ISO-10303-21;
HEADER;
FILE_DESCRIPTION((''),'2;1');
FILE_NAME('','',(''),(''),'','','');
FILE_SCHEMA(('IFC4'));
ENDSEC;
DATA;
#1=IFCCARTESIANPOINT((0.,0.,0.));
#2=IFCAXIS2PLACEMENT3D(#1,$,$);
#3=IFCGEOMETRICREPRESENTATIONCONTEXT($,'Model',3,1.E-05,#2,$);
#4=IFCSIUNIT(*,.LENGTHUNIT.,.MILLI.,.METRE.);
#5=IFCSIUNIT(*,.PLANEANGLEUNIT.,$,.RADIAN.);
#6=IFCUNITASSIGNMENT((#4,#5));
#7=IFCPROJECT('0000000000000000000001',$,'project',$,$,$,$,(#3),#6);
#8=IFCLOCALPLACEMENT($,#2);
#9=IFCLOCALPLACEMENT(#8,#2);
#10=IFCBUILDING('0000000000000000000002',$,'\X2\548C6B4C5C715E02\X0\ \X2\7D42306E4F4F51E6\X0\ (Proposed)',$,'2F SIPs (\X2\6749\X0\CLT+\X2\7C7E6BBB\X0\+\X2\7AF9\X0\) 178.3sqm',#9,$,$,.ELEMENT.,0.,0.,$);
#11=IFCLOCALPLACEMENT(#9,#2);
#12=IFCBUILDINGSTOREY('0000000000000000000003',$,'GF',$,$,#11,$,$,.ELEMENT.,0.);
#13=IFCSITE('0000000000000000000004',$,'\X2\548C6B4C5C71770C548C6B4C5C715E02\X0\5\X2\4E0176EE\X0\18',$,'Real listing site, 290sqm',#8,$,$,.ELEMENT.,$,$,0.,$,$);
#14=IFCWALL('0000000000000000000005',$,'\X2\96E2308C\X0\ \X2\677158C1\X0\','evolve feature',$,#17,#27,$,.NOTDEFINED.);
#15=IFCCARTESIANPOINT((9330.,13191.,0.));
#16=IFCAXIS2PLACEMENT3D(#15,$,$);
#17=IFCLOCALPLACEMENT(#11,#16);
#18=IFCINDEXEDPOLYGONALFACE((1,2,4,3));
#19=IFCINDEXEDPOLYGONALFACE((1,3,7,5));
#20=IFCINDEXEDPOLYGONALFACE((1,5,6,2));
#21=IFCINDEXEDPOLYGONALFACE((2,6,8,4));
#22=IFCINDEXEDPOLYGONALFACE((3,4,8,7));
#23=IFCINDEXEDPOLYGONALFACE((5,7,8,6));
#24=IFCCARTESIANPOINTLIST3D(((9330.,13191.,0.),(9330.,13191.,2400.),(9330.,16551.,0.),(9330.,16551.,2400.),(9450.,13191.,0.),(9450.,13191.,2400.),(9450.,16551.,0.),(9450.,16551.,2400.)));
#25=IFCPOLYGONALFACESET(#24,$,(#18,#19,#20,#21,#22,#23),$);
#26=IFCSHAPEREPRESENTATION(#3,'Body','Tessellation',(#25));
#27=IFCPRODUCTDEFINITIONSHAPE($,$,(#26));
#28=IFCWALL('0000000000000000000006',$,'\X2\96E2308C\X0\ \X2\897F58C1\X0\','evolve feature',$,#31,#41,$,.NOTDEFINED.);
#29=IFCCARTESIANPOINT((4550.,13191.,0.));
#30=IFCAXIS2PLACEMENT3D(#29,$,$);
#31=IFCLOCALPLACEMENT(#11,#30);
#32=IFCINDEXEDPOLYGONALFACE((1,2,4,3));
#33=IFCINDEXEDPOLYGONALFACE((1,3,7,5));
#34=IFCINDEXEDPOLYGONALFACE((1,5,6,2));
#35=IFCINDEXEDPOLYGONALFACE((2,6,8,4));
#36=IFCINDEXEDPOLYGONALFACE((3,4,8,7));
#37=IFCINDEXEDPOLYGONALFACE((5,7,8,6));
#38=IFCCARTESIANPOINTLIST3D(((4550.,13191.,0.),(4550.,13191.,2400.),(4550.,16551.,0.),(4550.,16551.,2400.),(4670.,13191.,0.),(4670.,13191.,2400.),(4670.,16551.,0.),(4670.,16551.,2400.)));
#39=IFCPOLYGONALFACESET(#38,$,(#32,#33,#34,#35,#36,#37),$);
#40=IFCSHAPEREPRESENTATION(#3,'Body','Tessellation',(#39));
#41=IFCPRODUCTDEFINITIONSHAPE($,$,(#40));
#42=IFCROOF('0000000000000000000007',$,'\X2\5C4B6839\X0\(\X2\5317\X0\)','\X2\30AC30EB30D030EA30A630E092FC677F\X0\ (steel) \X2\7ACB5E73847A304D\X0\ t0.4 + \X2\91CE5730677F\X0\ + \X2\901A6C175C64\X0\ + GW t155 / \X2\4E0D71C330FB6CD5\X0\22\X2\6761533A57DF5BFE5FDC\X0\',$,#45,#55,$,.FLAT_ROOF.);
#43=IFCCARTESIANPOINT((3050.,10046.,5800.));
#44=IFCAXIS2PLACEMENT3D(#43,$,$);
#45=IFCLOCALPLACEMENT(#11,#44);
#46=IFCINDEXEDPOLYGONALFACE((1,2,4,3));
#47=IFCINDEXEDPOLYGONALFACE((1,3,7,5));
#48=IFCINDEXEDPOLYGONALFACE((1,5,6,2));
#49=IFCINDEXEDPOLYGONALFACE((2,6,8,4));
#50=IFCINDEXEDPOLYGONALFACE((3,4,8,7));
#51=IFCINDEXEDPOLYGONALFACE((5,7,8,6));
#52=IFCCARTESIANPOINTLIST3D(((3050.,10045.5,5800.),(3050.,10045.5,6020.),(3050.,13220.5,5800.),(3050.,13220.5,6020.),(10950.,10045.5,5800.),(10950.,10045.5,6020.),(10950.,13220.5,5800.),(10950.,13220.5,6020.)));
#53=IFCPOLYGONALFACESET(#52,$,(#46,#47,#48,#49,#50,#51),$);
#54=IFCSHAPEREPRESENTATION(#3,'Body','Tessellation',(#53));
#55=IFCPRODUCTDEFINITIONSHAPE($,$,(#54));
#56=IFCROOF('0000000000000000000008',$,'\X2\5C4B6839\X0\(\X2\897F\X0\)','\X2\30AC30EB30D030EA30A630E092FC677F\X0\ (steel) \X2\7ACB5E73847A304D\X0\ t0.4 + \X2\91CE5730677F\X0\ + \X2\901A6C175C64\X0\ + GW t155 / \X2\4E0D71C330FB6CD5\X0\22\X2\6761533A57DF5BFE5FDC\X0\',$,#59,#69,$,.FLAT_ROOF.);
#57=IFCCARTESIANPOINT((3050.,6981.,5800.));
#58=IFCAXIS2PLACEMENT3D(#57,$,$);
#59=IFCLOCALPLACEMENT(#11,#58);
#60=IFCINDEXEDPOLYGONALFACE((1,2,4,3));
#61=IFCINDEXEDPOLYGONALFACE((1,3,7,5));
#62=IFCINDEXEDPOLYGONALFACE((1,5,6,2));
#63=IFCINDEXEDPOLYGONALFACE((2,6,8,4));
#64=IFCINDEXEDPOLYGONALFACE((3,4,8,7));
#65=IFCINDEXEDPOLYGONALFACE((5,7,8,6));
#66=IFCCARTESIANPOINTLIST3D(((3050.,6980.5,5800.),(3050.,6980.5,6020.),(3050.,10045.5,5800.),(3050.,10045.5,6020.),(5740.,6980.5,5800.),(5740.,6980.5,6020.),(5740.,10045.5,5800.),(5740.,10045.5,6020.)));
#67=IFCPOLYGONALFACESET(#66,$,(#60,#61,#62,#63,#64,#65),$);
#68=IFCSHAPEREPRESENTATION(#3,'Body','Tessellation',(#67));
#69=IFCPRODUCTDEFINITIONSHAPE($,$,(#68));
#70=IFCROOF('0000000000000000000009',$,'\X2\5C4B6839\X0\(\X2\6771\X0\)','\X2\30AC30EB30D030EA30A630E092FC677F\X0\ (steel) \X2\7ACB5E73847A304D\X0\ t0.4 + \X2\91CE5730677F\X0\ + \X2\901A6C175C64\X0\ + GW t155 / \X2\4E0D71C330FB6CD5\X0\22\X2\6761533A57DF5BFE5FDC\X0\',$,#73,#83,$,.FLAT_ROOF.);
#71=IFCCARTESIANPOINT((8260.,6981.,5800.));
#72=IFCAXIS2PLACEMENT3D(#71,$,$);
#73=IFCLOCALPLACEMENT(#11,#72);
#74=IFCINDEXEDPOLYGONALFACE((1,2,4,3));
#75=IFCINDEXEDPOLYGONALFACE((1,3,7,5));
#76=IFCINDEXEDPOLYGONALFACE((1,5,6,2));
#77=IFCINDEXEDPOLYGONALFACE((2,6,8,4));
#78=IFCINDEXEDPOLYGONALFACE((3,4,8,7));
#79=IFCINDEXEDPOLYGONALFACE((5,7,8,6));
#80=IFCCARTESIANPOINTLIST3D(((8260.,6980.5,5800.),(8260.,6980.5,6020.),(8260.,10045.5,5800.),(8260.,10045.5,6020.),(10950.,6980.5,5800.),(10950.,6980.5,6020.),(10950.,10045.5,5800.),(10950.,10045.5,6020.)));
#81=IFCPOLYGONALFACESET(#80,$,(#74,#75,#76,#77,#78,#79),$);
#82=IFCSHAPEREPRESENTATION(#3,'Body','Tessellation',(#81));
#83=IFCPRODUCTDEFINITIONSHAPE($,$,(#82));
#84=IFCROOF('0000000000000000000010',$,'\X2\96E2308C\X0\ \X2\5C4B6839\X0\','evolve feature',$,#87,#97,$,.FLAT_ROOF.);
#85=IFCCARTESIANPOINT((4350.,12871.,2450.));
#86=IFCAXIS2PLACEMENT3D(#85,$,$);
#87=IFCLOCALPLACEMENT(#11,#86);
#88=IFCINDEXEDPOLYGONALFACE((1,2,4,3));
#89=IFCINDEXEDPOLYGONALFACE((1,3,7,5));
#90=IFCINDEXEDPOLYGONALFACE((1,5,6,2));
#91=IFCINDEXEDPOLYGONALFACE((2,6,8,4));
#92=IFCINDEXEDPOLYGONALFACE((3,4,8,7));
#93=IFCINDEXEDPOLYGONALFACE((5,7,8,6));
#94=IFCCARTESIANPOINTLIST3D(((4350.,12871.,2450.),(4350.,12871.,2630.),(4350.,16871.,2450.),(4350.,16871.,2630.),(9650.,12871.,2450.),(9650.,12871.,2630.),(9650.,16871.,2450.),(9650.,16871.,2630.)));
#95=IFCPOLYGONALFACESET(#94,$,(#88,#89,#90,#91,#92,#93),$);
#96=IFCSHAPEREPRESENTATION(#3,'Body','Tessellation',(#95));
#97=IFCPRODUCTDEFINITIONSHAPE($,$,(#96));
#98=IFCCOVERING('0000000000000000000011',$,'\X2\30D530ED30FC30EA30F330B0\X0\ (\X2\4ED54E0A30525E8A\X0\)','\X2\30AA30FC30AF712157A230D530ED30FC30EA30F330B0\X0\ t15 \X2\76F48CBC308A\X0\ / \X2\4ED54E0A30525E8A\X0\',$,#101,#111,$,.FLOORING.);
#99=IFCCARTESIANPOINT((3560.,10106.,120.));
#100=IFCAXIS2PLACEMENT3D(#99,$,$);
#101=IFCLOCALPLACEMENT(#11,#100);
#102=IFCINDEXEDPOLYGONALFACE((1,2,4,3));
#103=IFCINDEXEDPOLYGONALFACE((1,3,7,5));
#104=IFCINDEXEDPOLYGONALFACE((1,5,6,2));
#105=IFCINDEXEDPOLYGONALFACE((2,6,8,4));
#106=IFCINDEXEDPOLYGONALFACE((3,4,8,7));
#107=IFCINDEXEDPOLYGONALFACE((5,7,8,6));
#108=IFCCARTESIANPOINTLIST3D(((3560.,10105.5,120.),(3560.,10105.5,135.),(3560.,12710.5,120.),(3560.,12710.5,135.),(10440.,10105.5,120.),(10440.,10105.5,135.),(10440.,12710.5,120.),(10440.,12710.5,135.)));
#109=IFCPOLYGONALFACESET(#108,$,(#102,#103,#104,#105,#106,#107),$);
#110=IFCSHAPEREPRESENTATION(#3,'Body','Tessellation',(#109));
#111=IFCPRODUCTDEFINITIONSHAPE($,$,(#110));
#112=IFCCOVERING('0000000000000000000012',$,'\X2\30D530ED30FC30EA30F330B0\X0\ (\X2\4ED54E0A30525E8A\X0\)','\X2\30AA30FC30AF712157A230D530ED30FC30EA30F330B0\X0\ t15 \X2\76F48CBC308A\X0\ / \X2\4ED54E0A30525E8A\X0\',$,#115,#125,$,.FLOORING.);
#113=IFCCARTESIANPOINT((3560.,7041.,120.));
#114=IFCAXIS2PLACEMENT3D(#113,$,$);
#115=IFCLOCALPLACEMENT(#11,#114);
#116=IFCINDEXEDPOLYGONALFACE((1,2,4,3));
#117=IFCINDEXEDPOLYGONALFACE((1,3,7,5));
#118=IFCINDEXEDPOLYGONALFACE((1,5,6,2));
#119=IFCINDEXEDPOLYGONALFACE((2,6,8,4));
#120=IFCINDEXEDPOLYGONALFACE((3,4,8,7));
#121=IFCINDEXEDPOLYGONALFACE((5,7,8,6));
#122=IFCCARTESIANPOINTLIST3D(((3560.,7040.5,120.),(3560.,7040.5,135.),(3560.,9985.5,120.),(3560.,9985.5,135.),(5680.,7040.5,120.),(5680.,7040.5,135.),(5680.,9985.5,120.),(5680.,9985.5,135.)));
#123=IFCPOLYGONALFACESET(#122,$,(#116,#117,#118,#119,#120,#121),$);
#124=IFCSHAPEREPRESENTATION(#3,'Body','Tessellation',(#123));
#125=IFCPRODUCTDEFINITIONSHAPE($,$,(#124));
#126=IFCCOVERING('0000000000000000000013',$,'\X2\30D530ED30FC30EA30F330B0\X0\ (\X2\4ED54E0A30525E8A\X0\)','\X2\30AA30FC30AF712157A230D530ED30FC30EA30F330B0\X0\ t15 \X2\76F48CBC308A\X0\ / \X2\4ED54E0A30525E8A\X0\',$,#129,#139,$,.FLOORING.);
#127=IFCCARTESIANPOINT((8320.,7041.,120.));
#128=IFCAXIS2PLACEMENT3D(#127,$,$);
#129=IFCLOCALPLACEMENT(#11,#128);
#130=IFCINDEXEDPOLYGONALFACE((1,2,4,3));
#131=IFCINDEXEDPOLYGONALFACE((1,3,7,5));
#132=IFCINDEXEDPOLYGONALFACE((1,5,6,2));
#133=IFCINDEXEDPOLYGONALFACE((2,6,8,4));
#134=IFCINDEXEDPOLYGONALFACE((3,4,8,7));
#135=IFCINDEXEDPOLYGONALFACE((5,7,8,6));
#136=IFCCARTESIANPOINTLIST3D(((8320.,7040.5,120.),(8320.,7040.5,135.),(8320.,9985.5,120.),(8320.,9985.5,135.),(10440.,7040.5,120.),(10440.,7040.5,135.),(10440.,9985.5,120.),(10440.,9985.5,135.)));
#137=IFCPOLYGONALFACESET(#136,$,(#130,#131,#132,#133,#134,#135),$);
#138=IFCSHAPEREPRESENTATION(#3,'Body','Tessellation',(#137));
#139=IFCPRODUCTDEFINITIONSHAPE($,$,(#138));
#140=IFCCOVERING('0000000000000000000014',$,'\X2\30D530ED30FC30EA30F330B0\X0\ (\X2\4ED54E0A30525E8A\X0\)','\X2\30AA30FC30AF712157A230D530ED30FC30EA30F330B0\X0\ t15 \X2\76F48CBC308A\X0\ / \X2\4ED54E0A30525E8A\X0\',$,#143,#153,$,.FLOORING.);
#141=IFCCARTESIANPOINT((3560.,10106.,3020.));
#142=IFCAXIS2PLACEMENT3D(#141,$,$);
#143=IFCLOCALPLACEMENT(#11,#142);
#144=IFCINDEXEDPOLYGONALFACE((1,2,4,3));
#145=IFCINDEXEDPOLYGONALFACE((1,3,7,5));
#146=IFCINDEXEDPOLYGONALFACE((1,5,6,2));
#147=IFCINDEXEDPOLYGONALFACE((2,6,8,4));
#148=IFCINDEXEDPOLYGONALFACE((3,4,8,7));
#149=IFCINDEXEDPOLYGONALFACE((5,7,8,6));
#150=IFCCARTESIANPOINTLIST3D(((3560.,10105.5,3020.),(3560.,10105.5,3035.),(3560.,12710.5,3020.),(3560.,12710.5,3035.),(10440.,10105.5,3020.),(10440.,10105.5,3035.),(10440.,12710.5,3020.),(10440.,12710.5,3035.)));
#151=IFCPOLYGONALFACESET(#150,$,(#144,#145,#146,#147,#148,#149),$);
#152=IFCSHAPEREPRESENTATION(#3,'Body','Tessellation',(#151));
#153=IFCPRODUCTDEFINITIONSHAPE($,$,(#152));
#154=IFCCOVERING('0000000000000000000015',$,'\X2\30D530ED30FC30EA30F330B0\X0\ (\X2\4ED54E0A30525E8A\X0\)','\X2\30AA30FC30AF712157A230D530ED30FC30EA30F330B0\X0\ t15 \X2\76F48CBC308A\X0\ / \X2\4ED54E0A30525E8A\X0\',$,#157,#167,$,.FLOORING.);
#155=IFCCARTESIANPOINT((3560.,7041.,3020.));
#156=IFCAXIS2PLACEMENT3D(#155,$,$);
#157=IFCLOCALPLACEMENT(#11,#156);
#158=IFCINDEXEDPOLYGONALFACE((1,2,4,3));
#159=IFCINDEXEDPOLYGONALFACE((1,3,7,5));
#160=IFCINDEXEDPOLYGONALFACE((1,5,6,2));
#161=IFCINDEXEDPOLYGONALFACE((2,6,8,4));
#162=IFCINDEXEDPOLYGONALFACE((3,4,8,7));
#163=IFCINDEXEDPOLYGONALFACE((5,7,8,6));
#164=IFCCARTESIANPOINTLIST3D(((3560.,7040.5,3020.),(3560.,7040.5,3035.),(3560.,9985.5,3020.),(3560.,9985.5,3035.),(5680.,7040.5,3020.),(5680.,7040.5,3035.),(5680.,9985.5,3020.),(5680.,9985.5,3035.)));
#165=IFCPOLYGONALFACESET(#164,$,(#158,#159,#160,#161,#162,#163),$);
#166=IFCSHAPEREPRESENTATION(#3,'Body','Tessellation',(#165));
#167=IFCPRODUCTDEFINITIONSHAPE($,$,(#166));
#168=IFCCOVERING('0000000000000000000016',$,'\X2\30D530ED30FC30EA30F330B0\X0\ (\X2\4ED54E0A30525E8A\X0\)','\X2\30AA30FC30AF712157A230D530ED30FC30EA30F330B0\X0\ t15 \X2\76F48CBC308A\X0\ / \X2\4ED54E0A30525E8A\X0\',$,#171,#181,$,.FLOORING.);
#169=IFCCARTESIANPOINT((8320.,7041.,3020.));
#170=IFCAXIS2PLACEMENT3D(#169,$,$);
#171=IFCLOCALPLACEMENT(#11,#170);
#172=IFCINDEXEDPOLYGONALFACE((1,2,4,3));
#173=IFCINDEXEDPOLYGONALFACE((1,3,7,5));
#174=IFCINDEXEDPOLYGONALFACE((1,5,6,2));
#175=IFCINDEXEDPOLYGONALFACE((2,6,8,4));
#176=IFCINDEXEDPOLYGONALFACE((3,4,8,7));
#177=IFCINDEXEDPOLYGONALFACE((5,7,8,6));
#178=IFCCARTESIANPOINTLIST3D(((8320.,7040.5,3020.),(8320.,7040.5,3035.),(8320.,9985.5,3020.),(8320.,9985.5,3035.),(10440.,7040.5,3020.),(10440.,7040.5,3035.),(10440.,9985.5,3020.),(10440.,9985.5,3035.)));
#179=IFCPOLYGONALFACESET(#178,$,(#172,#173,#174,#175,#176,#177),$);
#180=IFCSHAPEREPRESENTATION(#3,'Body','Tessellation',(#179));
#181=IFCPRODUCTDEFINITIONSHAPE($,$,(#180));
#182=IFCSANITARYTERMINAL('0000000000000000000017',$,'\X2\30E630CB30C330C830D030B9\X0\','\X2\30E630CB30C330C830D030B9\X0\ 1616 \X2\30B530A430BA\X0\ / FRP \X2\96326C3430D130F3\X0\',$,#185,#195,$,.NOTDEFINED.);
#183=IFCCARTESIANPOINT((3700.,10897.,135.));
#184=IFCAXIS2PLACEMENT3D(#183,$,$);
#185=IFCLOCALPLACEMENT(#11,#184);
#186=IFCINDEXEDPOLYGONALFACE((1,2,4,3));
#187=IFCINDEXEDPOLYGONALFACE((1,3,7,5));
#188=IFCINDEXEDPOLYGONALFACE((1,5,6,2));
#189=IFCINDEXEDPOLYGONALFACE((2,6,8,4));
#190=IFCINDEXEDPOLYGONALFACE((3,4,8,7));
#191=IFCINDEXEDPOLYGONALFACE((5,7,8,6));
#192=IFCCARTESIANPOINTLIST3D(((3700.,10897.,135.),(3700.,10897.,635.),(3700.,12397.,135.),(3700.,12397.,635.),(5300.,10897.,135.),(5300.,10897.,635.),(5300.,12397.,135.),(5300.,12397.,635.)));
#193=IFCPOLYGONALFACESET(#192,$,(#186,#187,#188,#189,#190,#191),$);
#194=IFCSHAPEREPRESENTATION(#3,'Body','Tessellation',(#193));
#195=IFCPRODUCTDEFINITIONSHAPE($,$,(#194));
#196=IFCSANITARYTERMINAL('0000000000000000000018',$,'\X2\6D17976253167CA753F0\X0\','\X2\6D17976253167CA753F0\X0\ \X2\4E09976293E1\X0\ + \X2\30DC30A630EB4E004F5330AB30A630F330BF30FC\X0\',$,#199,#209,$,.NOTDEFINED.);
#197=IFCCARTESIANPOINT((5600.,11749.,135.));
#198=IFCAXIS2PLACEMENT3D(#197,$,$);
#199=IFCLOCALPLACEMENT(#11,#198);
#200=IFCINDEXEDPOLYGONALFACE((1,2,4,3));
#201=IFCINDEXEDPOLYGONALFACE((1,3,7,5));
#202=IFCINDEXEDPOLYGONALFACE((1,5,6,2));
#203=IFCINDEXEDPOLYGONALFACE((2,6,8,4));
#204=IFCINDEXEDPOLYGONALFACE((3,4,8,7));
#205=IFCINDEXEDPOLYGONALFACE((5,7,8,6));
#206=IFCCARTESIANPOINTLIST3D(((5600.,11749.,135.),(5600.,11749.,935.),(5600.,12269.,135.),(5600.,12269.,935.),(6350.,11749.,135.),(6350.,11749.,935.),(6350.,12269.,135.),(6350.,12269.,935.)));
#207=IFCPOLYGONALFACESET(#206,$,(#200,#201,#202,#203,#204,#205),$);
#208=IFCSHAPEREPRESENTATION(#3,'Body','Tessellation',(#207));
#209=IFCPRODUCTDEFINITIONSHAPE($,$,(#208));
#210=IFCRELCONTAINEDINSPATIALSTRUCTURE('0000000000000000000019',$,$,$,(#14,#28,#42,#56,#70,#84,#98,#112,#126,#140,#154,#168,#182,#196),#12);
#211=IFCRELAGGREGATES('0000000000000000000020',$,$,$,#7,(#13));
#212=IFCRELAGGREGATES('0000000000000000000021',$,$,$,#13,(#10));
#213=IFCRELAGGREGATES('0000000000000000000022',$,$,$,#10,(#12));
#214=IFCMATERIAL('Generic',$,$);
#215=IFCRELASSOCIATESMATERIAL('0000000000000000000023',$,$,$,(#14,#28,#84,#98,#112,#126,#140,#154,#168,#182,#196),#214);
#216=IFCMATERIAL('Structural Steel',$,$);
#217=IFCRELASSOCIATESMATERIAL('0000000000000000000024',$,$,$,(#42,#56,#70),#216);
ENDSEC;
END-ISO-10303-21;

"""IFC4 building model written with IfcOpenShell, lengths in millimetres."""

from ifc_helpers import new_model, si_unit, frame, frame_2d, origin, place, context, project, spatial, rectangle, extrude, material, element, save


model = new_model("IFC4")

# Units and contexts
model_context = context("Model", 3, precision=1e-05, world=origin())
ifc_project = project(units=[si_unit("LENGTHUNIT", "METRE", prefix="MILLI"), si_unit("PLANEANGLEUNIT", "RADIAN")], contexts=[model_context])

# Site, building, storey
site_placement = place(None, origin())
site = spatial("IfcSite", under=ifc_project, at=site_placement, Name="和歌山県和歌山市5丁目18", ObjectType="Real listing site, 290sqm", CompositionType="ELEMENT", RefElevation=0.0)
building_placement = place(site_placement, origin())
building = spatial("IfcBuilding", under=site, at=building_placement, Name="和歌山市 終の住処 (Proposed)", ObjectType="2F SIPs (杉CLT+籾殻+竹) 178.3sqm", CompositionType="ELEMENT", ElevationOfRefHeight=0.0, ElevationOfTerrain=0.0)
storey_placement = place(building_placement, origin())
storey = spatial("IfcBuildingStorey", under=building, at=storey_placement, Name="GF", CompositionType="ELEMENT", Elevation=0.0)

# Shared definitions
ifc_material_1 = material(Name="Generic")

# Walls
wall_1_placement = place(storey_placement, frame((9330.0, 13191.0, 0.0)))
element("IfcWall", 1, at=wall_1_placement, inside=storey, material=ifc_material_1, Name="離れ 東壁", Description="evolve feature", PredefinedType="NOTDEFINED", context=model_context, shape_type="SweptSolid", body=[
    extrude(rectangle(XDim=120.0, YDim=3360.0, at=frame_2d((60.0, 1680.0))), frame((9330.0, 13191.0, 0.0)), (0.0, 0.0, 1.0), 2400.0),
])
wall_2_placement = place(storey_placement, frame((4550.0, 13191.0, 0.0)))
element("IfcWall", 2, at=wall_2_placement, inside=storey, material=ifc_material_1, Name="離れ 西壁", Description="evolve feature", PredefinedType="NOTDEFINED", context=model_context, shape_type="SweptSolid", body=[
    extrude(rectangle(XDim=120.0, YDim=3360.0, at=frame_2d((60.0, 1680.0))), frame((4550.0, 13191.0, 0.0)), (0.0, 0.0, 1.0), 2400.0),
])

# Roofs
ifc_material_2 = material(Name="Structural Steel")
for number, where, name in (
    (3, (3050.0, 10046.0, 5800.0), "屋根(北)"),
):
    element("IfcRoof", number, at=place(storey_placement, frame(where)), inside=storey, material=ifc_material_2, Name=name, Description="ガルバリウム鋼板 (steel) 立平葺き t0.4 + 野地板 + 通気層 + GW t155 / 不燃・法22条区域対応", PredefinedType="FLAT_ROOF", context=model_context, shape_type="SweptSolid", body=[
        extrude(rectangle(XDim=7900.0, YDim=3175.0, at=frame_2d((3950.0, 1587.0))), frame((3050.0, 10046.0, 5800.0)), (0.0, 0.0, 1.0), 220.0),
    ])
roof_1_placement = place(storey_placement, frame((3050.0, 6981.0, 5800.0)))
element("IfcRoof", 4, at=roof_1_placement, inside=storey, material=ifc_material_2, Name="屋根(西)", Description="ガルバリウム鋼板 (steel) 立平葺き t0.4 + 野地板 + 通気層 + GW t155 / 不燃・法22条区域対応", PredefinedType="FLAT_ROOF", context=model_context, shape_type="SweptSolid", body=[
    extrude(rectangle(XDim=2690.0, YDim=3065.0, at=frame_2d((1345.0, 1532.0))), frame((3050.0, 6981.0, 5800.0)), (0.0, 0.0, 1.0), 220.0),
])
roof_2_placement = place(storey_placement, frame((8260.0, 6981.0, 5800.0)))
element("IfcRoof", 5, at=roof_2_placement, inside=storey, material=ifc_material_2, Name="屋根(東)", Description="ガルバリウム鋼板 (steel) 立平葺き t0.4 + 野地板 + 通気層 + GW t155 / 不燃・法22条区域対応", PredefinedType="FLAT_ROOF", context=model_context, shape_type="SweptSolid", body=[
    extrude(rectangle(XDim=2690.0, YDim=3065.0, at=frame_2d((1345.0, 1532.0))), frame((8260.0, 6981.0, 5800.0)), (0.0, 0.0, 1.0), 220.0),
])
roof_3_placement = place(storey_placement, frame((4350.0, 12871.0, 2450.0)))
element("IfcRoof", 6, at=roof_3_placement, inside=storey, material=ifc_material_1, Name="離れ 屋根", Description="evolve feature", PredefinedType="FLAT_ROOF", context=model_context, shape_type="SweptSolid", body=[
    extrude(rectangle(XDim=5300.0, YDim=4000.0, at=frame_2d((2650.0, 2000.0))), frame((4350.0, 12871.0, 2450.0)), (0.0, 0.0, 1.0), 180.0),
])

# Coverings
covering_1_placement = place(storey_placement, frame((3560.0, 10106.0, 120.0)))
element("IfcCovering", 7, at=covering_1_placement, inside=storey, material=ifc_material_1, Name="フローリング (仕上げ床)", Description="オーク無垢フローリング t15 直貼り / 仕上げ床", PredefinedType="FLOORING", context=model_context, shape_type="SweptSolid", body=[
    extrude(rectangle(XDim=6880.0, YDim=2605.0, at=frame_2d((3440.0, 1302.0))), frame((3560.0, 10106.0, 120.0)), (0.0, 0.0, 1.0), 15.0),
])
covering_2_placement = place(storey_placement, frame((3560.0, 7041.0, 120.0)))
element("IfcCovering", 8, at=covering_2_placement, inside=storey, material=ifc_material_1, Name="フローリング (仕上げ床)", Description="オーク無垢フローリング t15 直貼り / 仕上げ床", PredefinedType="FLOORING", context=model_context, shape_type="SweptSolid", body=[
    extrude(rectangle(XDim=2120.0, YDim=2945.0, at=frame_2d((1060.0, 1472.0))), frame((3560.0, 7041.0, 120.0)), (0.0, 0.0, 1.0), 15.0),
])
covering_3_placement = place(storey_placement, frame((8320.0, 7041.0, 120.0)))
element("IfcCovering", 9, at=covering_3_placement, inside=storey, material=ifc_material_1, Name="フローリング (仕上げ床)", Description="オーク無垢フローリング t15 直貼り / 仕上げ床", PredefinedType="FLOORING", context=model_context, shape_type="SweptSolid", body=[
    extrude(rectangle(XDim=2120.0, YDim=2945.0, at=frame_2d((1060.0, 1472.0))), frame((8320.0, 7041.0, 120.0)), (0.0, 0.0, 1.0), 15.0),
])
covering_4_placement = place(storey_placement, frame((3560.0, 10106.0, 3020.0)))
element("IfcCovering", 10, at=covering_4_placement, inside=storey, material=ifc_material_1, Name="フローリング (仕上げ床)", Description="オーク無垢フローリング t15 直貼り / 仕上げ床", PredefinedType="FLOORING", context=model_context, shape_type="SweptSolid", body=[
    extrude(rectangle(XDim=6880.0, YDim=2605.0, at=frame_2d((3440.0, 1302.0))), frame((3560.0, 10106.0, 3020.0)), (0.0, 0.0, 1.0), 15.0),
])
covering_5_placement = place(storey_placement, frame((3560.0, 7041.0, 3020.0)))
element("IfcCovering", 11, at=covering_5_placement, inside=storey, material=ifc_material_1, Name="フローリング (仕上げ床)", Description="オーク無垢フローリング t15 直貼り / 仕上げ床", PredefinedType="FLOORING", context=model_context, shape_type="SweptSolid", body=[
    extrude(rectangle(XDim=2120.0, YDim=2945.0, at=frame_2d((1060.0, 1472.0))), frame((3560.0, 7041.0, 3020.0)), (0.0, 0.0, 1.0), 15.0),
])
covering_6_placement = place(storey_placement, frame((8320.0, 7041.0, 3020.0)))
element("IfcCovering", 12, at=covering_6_placement, inside=storey, material=ifc_material_1, Name="フローリング (仕上げ床)", Description="オーク無垢フローリング t15 直貼り / 仕上げ床", PredefinedType="FLOORING", context=model_context, shape_type="SweptSolid", body=[
    extrude(rectangle(XDim=2120.0, YDim=2945.0, at=frame_2d((1060.0, 1472.0))), frame((8320.0, 7041.0, 3020.0)), (0.0, 0.0, 1.0), 15.0),
])

# Sanitary terminals
sanitary_terminal_1_placement = place(storey_placement, frame((3700.0, 10897.0, 135.0)))
element("IfcSanitaryTerminal", 13, at=sanitary_terminal_1_placement, inside=storey, material=ifc_material_1, Name="ユニットバス", Description="ユニットバス 1616 サイズ / FRP 防水パン", PredefinedType="NOTDEFINED", context=model_context, shape_type="SweptSolid", body=[
    extrude(rectangle(XDim=1600.0, YDim=1500.0, at=frame_2d((800.0, 750.0))), frame((3700.0, 10897.0, 135.0)), (0.0, 0.0, 1.0), 500.0),
])
sanitary_terminal_2_placement = place(storey_placement, frame((5600.0, 11749.0, 135.0)))
element("IfcSanitaryTerminal", 14, at=sanitary_terminal_2_placement, inside=storey, material=ifc_material_1, Name="洗面化粧台", Description="洗面化粧台 三面鏡 + ボウル一体カウンター", PredefinedType="NOTDEFINED", context=model_context, shape_type="SweptSolid", body=[
    extrude(rectangle(XDim=750.0, YDim=520.0, at=frame_2d((375.0, 260.0))), frame((5600.0, 11749.0, 135.0)), (0.0, 0.0, 1.0), 800.0),
])

save(model, "model.ifc")
